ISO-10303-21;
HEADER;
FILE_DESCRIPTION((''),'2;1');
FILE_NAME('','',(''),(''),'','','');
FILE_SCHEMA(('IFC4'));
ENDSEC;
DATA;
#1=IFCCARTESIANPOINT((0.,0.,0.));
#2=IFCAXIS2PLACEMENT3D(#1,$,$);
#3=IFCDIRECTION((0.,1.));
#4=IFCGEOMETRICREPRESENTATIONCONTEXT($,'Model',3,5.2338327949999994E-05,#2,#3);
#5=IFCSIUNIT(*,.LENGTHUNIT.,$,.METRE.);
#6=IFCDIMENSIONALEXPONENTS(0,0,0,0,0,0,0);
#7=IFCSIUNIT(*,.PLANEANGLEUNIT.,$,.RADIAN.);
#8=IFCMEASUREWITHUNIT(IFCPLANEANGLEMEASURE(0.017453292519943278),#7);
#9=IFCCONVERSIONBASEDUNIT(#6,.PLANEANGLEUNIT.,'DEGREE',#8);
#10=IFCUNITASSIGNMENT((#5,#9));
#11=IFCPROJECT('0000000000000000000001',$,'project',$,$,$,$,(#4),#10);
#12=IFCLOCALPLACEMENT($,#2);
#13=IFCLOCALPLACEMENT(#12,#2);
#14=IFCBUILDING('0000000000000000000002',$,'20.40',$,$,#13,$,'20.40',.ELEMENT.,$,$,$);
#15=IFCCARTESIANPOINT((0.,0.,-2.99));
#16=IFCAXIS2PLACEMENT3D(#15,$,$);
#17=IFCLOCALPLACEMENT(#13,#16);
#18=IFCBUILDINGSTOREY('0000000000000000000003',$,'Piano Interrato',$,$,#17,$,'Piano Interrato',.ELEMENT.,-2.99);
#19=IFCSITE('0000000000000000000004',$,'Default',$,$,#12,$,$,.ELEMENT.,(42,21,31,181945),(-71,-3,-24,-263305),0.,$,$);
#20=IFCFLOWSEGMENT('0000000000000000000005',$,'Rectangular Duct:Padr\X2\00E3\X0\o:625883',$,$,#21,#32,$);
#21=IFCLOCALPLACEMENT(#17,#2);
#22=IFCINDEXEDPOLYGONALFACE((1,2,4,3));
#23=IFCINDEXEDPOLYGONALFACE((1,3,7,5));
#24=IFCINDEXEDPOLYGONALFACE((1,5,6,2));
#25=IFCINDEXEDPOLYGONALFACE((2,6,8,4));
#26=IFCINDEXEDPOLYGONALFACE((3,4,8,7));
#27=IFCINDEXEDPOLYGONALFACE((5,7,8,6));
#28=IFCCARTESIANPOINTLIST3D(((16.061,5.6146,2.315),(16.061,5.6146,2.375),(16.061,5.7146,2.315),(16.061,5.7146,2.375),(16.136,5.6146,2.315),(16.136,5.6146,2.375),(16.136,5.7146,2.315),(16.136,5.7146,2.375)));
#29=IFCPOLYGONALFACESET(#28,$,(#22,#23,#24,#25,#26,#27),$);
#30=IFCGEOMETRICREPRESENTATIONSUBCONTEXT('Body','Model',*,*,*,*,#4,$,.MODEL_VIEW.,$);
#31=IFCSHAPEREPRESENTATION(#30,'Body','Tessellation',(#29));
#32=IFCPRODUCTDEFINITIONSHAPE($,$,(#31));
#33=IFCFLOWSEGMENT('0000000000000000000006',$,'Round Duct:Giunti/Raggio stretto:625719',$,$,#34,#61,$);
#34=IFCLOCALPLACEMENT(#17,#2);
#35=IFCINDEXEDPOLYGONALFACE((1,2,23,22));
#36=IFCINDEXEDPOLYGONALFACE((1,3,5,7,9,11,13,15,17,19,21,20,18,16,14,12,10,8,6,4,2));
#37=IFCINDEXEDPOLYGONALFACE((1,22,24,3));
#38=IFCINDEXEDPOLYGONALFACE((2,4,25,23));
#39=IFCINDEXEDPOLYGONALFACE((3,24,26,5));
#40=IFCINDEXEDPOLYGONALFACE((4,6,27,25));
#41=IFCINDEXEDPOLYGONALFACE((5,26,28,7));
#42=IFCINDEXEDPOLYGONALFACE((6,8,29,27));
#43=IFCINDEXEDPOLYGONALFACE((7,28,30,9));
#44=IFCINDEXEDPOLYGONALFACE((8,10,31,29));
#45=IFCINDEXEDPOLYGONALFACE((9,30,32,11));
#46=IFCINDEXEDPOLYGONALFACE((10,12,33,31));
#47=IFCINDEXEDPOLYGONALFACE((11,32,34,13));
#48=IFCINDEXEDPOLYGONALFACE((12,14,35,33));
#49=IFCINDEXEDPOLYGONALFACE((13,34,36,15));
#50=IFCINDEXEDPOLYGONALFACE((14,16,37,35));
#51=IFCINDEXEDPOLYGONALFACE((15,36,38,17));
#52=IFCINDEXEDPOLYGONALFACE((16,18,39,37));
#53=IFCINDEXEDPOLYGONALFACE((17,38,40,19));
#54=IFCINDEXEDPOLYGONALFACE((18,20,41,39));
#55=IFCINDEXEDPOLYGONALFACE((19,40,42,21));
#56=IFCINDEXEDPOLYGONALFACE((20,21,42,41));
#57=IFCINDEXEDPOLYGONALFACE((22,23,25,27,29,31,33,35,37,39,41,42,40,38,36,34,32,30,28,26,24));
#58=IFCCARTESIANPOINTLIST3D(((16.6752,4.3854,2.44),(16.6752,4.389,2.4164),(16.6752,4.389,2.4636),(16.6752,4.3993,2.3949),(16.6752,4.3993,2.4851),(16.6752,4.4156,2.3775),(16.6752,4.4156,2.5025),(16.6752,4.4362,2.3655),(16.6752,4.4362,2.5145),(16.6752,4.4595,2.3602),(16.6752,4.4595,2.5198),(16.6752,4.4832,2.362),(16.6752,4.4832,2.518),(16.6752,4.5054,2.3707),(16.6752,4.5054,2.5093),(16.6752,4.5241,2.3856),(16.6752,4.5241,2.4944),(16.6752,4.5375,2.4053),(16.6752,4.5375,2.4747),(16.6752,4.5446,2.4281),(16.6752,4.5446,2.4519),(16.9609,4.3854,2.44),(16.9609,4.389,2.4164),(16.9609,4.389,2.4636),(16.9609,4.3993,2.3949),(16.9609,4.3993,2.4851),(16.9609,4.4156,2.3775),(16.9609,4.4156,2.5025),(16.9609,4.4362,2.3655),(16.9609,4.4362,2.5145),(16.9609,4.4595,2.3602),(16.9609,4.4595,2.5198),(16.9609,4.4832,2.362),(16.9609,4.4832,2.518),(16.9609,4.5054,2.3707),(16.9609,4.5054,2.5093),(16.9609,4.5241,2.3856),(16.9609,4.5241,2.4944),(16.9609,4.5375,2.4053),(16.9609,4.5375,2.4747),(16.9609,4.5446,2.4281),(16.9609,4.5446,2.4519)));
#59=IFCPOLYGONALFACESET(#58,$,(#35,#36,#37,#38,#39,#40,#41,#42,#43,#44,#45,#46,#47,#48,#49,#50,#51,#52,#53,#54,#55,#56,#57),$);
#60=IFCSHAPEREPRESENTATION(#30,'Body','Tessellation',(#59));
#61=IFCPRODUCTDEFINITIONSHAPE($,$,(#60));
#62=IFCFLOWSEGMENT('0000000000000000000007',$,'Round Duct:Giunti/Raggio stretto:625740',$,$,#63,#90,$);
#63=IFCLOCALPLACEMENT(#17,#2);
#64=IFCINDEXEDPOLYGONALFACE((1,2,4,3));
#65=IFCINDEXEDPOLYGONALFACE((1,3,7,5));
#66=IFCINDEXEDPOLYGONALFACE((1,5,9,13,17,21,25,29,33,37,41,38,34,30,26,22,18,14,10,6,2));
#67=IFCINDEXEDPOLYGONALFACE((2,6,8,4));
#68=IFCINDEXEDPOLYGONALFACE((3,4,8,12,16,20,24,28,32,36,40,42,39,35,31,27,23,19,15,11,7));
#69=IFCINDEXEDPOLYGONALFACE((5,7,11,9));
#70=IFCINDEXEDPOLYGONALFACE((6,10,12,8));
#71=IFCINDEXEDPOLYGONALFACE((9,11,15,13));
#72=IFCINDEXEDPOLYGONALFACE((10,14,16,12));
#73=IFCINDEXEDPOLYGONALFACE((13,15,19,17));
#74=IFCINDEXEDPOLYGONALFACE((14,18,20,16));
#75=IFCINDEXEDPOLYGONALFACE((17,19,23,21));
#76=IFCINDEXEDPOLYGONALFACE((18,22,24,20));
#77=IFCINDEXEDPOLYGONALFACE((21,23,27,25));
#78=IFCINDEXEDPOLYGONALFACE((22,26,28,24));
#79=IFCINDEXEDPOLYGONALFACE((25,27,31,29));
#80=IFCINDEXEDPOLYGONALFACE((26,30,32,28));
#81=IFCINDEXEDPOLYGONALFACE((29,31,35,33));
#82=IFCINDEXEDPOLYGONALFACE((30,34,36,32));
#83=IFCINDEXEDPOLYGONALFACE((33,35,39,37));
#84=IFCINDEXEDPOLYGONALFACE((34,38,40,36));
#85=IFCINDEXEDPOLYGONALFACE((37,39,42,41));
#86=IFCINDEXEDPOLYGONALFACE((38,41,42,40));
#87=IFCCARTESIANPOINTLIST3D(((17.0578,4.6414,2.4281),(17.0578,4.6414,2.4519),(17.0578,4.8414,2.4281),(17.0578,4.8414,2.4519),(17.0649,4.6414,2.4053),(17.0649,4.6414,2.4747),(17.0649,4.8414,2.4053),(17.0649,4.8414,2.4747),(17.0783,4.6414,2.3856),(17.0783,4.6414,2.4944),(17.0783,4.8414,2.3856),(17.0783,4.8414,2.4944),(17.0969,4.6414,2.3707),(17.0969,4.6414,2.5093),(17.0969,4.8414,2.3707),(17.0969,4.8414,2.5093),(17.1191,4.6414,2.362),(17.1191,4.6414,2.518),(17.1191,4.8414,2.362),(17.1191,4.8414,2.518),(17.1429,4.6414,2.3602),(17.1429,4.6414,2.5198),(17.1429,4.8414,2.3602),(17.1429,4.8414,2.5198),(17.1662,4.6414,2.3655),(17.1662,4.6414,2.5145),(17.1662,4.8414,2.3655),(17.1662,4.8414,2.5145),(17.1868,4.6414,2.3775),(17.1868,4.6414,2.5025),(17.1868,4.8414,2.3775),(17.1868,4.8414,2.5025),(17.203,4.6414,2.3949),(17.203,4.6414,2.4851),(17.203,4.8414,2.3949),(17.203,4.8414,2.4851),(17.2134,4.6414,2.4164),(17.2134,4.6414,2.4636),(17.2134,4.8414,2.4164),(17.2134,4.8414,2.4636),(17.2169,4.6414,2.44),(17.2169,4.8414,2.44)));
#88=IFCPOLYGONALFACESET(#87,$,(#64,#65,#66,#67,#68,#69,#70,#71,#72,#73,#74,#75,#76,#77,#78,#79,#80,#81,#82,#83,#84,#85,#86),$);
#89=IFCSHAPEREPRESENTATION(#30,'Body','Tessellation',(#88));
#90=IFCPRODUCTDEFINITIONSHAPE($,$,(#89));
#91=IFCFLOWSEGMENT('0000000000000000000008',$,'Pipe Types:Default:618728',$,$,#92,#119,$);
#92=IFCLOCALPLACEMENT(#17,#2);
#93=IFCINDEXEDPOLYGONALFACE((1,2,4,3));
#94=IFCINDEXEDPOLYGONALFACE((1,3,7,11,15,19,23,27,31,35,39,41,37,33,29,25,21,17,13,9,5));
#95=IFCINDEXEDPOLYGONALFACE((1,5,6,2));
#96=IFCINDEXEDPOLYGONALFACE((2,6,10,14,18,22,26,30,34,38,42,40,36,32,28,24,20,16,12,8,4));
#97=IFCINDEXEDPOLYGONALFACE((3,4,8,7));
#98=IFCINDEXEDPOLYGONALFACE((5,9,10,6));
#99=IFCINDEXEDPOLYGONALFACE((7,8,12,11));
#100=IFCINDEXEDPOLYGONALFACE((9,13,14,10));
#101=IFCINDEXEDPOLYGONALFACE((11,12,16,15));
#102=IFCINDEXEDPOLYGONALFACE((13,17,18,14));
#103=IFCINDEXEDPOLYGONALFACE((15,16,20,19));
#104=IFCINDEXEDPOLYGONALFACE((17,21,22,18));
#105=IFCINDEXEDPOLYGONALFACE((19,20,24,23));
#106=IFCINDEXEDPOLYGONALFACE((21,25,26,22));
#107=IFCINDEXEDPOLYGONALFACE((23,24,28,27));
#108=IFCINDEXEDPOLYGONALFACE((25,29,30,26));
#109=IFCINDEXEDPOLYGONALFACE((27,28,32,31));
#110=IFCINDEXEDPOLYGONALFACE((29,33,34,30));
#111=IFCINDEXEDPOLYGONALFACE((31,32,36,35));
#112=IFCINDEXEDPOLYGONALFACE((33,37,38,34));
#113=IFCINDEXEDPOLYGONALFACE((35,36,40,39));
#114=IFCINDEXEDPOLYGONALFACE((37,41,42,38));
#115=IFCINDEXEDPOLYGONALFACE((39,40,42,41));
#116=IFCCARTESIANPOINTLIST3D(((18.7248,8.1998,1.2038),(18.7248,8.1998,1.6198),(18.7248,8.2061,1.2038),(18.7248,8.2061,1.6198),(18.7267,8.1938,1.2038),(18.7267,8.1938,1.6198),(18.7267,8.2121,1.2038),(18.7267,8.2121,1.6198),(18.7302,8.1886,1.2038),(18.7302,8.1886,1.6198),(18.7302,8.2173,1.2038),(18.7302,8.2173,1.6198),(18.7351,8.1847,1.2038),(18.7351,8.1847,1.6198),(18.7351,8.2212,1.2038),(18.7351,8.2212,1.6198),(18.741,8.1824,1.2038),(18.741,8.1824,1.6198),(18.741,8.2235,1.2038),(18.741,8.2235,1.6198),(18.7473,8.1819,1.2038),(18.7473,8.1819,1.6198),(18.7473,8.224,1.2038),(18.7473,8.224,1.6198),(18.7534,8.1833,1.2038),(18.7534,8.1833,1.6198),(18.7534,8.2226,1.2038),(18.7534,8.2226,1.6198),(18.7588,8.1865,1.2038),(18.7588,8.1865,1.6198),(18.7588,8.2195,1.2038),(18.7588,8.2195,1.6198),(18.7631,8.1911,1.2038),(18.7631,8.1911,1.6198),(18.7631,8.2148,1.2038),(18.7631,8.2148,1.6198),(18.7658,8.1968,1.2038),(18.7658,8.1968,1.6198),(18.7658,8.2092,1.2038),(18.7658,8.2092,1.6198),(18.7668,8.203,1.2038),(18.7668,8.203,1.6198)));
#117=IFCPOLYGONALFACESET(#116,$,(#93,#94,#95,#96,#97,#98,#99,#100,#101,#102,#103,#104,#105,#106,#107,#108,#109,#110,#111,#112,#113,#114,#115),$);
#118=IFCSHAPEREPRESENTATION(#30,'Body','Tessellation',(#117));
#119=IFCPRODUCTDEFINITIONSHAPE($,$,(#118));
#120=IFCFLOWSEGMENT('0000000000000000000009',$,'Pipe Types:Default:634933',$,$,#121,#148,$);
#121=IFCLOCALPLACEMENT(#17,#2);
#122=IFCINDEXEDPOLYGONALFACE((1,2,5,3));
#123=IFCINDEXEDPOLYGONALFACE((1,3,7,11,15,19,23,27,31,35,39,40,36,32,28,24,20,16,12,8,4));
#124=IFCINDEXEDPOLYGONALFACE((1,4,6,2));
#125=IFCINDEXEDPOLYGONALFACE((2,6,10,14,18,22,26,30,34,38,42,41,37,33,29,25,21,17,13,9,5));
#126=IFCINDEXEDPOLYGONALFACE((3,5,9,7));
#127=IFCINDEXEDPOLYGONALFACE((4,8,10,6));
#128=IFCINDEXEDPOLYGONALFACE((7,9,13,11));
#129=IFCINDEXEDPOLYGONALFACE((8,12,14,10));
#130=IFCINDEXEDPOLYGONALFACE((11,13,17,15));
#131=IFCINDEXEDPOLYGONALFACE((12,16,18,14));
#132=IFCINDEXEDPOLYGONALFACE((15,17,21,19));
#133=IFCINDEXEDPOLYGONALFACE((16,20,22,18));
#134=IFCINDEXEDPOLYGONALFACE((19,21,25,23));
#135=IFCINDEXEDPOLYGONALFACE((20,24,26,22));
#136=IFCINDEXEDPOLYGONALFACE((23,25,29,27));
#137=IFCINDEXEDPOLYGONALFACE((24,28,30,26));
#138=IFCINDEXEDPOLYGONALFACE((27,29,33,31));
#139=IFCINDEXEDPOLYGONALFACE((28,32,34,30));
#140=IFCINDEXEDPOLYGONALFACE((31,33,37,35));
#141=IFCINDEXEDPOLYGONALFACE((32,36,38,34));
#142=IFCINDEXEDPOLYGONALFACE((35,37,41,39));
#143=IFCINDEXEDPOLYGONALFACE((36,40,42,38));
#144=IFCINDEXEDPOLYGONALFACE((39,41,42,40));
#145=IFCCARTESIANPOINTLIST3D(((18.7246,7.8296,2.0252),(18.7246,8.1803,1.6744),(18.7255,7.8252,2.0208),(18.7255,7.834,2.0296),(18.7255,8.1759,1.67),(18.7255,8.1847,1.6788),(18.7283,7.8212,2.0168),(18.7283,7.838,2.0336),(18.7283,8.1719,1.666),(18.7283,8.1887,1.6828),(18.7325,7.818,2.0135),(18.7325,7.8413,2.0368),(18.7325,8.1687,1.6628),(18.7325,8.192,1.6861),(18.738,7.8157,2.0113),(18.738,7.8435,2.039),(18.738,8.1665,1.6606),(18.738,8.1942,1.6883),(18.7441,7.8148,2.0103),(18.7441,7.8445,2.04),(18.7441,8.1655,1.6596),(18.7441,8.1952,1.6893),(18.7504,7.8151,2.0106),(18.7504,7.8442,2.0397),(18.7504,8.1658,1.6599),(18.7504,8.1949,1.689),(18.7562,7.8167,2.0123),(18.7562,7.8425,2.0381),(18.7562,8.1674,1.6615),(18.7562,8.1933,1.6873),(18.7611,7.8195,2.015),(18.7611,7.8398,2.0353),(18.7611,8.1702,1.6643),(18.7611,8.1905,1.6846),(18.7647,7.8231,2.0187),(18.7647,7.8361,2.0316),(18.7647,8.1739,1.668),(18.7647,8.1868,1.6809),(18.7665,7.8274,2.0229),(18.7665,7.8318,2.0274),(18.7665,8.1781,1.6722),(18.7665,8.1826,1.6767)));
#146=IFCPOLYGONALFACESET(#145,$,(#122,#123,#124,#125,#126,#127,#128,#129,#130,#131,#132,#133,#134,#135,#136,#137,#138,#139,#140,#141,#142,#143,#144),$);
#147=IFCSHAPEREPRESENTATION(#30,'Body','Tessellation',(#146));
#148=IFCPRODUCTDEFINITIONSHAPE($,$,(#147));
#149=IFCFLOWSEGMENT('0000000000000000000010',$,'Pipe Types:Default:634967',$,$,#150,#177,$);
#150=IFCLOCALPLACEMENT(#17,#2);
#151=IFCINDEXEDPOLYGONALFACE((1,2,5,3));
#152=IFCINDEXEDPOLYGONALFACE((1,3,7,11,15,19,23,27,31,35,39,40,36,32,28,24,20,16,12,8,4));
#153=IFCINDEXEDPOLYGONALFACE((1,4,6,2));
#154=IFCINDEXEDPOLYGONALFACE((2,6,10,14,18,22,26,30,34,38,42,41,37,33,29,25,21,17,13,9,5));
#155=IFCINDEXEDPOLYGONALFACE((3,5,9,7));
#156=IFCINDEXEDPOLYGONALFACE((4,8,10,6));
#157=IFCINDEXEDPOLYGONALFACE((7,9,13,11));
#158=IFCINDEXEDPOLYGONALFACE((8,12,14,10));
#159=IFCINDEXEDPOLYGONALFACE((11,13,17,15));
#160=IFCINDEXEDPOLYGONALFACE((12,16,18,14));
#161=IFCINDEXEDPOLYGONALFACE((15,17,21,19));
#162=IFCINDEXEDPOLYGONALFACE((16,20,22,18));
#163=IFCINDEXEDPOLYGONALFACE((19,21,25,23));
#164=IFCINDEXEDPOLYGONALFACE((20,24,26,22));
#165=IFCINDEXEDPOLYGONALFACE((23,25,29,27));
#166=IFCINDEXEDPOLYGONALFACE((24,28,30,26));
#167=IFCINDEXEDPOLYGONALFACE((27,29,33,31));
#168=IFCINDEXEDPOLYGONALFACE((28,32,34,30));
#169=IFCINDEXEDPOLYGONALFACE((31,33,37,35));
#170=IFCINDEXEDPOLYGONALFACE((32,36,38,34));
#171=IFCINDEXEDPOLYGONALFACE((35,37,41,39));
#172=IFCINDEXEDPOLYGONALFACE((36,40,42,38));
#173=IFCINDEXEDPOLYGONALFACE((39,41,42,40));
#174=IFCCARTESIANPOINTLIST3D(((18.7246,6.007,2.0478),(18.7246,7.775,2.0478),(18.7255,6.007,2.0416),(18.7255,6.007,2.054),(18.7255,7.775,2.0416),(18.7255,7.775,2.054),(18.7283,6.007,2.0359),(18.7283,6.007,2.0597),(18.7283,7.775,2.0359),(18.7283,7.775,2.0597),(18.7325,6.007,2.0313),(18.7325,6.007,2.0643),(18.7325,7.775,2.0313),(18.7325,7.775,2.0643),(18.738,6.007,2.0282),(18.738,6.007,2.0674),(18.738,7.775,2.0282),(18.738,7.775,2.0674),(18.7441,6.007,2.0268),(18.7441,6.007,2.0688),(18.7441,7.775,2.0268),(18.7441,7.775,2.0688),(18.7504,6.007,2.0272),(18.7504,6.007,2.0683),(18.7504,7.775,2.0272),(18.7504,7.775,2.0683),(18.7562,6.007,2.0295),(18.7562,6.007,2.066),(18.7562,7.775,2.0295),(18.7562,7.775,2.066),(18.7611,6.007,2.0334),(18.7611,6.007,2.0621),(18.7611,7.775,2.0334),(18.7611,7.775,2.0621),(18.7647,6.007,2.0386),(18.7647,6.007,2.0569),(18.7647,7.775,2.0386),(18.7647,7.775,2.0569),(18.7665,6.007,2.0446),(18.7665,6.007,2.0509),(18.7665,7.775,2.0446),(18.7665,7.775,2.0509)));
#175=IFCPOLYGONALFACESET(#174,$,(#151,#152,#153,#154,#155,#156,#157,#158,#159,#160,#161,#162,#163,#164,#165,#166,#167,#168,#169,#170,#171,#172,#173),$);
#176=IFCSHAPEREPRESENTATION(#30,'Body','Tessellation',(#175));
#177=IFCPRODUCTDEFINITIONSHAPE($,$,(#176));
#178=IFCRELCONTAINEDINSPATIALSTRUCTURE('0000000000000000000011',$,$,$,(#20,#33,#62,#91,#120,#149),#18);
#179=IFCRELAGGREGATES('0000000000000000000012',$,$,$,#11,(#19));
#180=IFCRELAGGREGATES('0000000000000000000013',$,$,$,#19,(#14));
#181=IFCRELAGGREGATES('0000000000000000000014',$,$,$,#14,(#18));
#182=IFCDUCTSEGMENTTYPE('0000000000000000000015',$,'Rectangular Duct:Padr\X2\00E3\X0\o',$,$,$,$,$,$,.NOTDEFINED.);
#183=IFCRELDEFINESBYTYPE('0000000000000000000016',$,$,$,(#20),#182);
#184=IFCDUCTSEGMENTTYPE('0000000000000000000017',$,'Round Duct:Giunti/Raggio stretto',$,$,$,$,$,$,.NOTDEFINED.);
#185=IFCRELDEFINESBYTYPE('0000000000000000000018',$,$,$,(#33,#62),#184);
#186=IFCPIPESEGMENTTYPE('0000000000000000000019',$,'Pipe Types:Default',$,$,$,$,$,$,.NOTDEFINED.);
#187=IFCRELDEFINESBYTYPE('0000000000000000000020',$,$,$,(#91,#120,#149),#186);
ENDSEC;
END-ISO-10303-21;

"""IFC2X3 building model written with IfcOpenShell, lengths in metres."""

from ifc_helpers import new_model, entity, si_unit, converted_unit, direction, frame, frame_2d, origin, place, context, subcontext, project, spatial, rectangle, circle, extrude, type_object, element, save


model = new_model("IFC2X3")

# Units and contexts
model_context = context("Model", 3, precision=5.2338327949999994e-05, world=origin(), true_north=direction((0.0, 1.0)))
body_context = subcontext(model_context, "Body", "Model", "MODEL_VIEW")
ifc_project = project(units=[si_unit("LENGTHUNIT", "METRE"), converted_unit("PLANEANGLEUNIT", "DEGREE", entity("IfcPlaneAngleMeasure", 0.017453292519943278), si_unit("PLANEANGLEUNIT", "RADIAN"), dimensions=[0, 0, 0, 0, 0, 0, 0])], contexts=[model_context])

# Site, building, storey
site_placement = place(None, origin())
site = spatial("IfcSite", under=ifc_project, at=site_placement, Name="Default", CompositionType="ELEMENT", RefLatitude=(42, 21, 31, 181945), RefLongitude=(-71, -3, -24, -263305), RefElevation=0.0)
building_placement = place(site_placement, origin())
building = spatial("IfcBuilding", under=site, at=building_placement, Name="20.40", LongName="20.40", CompositionType="ELEMENT")
storey_placement = place(building_placement, frame((0.0, 0.0, -2.99)))
storey = spatial("IfcBuildingStorey", under=building, at=storey_placement, Name="Piano Interrato", LongName="Piano Interrato", CompositionType="ELEMENT", Elevation=-2.99)

# Flow segments
duct_segment_type_1 = type_object("IfcDuctSegmentType", Name="Rectangular Duct:Padrão", PredefinedType="NOTDEFINED")
flow_segment_1_placement = place(storey_placement, origin())
element("IfcFlowSegment", 1, at=flow_segment_1_placement, inside=storey, type_object=duct_segment_type_1, Name="Rectangular Duct:Padrão:625883", context=body_context, shape_type="SweptSolid", body=[
    extrude(rectangle(XDim=0.075, YDim=0.1, at=frame_2d((0.0, 0.0), x_axis=(1.0, 0.0))), frame((16.0985, 5.6646, 2.315)), (0.0, 0.0, 1.0), 0.06),
])
duct_segment_type_2 = type_object("IfcDuctSegmentType", Name="Round Duct:Giunti/Raggio stretto", PredefinedType="NOTDEFINED")
flow_segment_2_placement = place(storey_placement, origin())
element("IfcFlowSegment", 2, at=flow_segment_2_placement, inside=storey, type_object=duct_segment_type_2, Name="Round Duct:Giunti/Raggio stretto:625719", context=body_context, shape_type="SweptSolid", body=[
    extrude(circle(Radius=0.08, at=frame_2d((0.0, 0.0), x_axis=(1.0, 0.0))), frame((16.6752, 4.4654, 2.44), z_axis=(1.0, 0.0, 0.0), x_axis=(0.0, -1.0, 0.0)), (0.0, 0.0, 1.0), 0.2857),
])
flow_segment_3_placement = place(storey_placement, origin())
element("IfcFlowSegment", 3, at=flow_segment_3_placement, inside=storey, type_object=duct_segment_type_2, Name="Round Duct:Giunti/Raggio stretto:625740", context=body_context, shape_type="SweptSolid", body=[
    extrude(circle(Radius=0.08, at=frame_2d((0.0, 0.0), x_axis=(1.0, 0.0))), frame((17.1369, 4.6414, 2.44), z_axis=(0.0, 1.0, 0.0), x_axis=(1.0, 0.0, 0.0)), (0.0, 0.0, 1.0), 0.1999),
])
pipe_segment_type_1 = type_object("IfcPipeSegmentType", Name="Pipe Types:Default", PredefinedType="NOTDEFINED")
flow_segment_4_placement = place(storey_placement, origin())
element("IfcFlowSegment", 4, at=flow_segment_4_placement, inside=storey, type_object=pipe_segment_type_1, Name="Pipe Types:Default:618728", context=body_context, shape_type="SweptSolid", body=[
    extrude(circle(Radius=0.0211, at=frame_2d((0.0, 0.0), x_axis=(1.0, 0.0))), frame((18.7457, 8.203, 1.2038)), (0.0, 0.0, 1.0), 0.416),
])
flow_segment_5_placement = place(storey_placement, origin())
element("IfcFlowSegment", 5, at=flow_segment_5_placement, inside=storey, type_object=pipe_segment_type_1, Name="Pipe Types:Default:634933", context=body_context, shape_type="SweptSolid", body=[
    extrude(circle(Radius=0.0211, at=frame_2d((0.0, 0.0), x_axis=(1.0, 0.0))), frame((18.7457, 7.8296, 2.0252), z_axis=(0.0, 0.707107, -0.707107), x_axis=(-1.0, 0.0, 0.0)), (0.0, 0.0, 1.0), 0.496),
])
flow_segment_6_placement = place(storey_placement, origin())
element("IfcFlowSegment", 6, at=flow_segment_6_placement, inside=storey, type_object=pipe_segment_type_1, Name="Pipe Types:Default:634967", context=body_context, shape_type="SweptSolid", body=[
    extrude(circle(Radius=0.0211, at=frame_2d((0.0, 0.0), x_axis=(1.0, 0.0))), frame((18.7457, 6.007, 2.0478), z_axis=(0.0, 1.0, 0.0), x_axis=(-1.0, 0.0, 0.0)), (0.0, 0.0, 1.0), 1.768),
])

save(model, "model.ifc")
